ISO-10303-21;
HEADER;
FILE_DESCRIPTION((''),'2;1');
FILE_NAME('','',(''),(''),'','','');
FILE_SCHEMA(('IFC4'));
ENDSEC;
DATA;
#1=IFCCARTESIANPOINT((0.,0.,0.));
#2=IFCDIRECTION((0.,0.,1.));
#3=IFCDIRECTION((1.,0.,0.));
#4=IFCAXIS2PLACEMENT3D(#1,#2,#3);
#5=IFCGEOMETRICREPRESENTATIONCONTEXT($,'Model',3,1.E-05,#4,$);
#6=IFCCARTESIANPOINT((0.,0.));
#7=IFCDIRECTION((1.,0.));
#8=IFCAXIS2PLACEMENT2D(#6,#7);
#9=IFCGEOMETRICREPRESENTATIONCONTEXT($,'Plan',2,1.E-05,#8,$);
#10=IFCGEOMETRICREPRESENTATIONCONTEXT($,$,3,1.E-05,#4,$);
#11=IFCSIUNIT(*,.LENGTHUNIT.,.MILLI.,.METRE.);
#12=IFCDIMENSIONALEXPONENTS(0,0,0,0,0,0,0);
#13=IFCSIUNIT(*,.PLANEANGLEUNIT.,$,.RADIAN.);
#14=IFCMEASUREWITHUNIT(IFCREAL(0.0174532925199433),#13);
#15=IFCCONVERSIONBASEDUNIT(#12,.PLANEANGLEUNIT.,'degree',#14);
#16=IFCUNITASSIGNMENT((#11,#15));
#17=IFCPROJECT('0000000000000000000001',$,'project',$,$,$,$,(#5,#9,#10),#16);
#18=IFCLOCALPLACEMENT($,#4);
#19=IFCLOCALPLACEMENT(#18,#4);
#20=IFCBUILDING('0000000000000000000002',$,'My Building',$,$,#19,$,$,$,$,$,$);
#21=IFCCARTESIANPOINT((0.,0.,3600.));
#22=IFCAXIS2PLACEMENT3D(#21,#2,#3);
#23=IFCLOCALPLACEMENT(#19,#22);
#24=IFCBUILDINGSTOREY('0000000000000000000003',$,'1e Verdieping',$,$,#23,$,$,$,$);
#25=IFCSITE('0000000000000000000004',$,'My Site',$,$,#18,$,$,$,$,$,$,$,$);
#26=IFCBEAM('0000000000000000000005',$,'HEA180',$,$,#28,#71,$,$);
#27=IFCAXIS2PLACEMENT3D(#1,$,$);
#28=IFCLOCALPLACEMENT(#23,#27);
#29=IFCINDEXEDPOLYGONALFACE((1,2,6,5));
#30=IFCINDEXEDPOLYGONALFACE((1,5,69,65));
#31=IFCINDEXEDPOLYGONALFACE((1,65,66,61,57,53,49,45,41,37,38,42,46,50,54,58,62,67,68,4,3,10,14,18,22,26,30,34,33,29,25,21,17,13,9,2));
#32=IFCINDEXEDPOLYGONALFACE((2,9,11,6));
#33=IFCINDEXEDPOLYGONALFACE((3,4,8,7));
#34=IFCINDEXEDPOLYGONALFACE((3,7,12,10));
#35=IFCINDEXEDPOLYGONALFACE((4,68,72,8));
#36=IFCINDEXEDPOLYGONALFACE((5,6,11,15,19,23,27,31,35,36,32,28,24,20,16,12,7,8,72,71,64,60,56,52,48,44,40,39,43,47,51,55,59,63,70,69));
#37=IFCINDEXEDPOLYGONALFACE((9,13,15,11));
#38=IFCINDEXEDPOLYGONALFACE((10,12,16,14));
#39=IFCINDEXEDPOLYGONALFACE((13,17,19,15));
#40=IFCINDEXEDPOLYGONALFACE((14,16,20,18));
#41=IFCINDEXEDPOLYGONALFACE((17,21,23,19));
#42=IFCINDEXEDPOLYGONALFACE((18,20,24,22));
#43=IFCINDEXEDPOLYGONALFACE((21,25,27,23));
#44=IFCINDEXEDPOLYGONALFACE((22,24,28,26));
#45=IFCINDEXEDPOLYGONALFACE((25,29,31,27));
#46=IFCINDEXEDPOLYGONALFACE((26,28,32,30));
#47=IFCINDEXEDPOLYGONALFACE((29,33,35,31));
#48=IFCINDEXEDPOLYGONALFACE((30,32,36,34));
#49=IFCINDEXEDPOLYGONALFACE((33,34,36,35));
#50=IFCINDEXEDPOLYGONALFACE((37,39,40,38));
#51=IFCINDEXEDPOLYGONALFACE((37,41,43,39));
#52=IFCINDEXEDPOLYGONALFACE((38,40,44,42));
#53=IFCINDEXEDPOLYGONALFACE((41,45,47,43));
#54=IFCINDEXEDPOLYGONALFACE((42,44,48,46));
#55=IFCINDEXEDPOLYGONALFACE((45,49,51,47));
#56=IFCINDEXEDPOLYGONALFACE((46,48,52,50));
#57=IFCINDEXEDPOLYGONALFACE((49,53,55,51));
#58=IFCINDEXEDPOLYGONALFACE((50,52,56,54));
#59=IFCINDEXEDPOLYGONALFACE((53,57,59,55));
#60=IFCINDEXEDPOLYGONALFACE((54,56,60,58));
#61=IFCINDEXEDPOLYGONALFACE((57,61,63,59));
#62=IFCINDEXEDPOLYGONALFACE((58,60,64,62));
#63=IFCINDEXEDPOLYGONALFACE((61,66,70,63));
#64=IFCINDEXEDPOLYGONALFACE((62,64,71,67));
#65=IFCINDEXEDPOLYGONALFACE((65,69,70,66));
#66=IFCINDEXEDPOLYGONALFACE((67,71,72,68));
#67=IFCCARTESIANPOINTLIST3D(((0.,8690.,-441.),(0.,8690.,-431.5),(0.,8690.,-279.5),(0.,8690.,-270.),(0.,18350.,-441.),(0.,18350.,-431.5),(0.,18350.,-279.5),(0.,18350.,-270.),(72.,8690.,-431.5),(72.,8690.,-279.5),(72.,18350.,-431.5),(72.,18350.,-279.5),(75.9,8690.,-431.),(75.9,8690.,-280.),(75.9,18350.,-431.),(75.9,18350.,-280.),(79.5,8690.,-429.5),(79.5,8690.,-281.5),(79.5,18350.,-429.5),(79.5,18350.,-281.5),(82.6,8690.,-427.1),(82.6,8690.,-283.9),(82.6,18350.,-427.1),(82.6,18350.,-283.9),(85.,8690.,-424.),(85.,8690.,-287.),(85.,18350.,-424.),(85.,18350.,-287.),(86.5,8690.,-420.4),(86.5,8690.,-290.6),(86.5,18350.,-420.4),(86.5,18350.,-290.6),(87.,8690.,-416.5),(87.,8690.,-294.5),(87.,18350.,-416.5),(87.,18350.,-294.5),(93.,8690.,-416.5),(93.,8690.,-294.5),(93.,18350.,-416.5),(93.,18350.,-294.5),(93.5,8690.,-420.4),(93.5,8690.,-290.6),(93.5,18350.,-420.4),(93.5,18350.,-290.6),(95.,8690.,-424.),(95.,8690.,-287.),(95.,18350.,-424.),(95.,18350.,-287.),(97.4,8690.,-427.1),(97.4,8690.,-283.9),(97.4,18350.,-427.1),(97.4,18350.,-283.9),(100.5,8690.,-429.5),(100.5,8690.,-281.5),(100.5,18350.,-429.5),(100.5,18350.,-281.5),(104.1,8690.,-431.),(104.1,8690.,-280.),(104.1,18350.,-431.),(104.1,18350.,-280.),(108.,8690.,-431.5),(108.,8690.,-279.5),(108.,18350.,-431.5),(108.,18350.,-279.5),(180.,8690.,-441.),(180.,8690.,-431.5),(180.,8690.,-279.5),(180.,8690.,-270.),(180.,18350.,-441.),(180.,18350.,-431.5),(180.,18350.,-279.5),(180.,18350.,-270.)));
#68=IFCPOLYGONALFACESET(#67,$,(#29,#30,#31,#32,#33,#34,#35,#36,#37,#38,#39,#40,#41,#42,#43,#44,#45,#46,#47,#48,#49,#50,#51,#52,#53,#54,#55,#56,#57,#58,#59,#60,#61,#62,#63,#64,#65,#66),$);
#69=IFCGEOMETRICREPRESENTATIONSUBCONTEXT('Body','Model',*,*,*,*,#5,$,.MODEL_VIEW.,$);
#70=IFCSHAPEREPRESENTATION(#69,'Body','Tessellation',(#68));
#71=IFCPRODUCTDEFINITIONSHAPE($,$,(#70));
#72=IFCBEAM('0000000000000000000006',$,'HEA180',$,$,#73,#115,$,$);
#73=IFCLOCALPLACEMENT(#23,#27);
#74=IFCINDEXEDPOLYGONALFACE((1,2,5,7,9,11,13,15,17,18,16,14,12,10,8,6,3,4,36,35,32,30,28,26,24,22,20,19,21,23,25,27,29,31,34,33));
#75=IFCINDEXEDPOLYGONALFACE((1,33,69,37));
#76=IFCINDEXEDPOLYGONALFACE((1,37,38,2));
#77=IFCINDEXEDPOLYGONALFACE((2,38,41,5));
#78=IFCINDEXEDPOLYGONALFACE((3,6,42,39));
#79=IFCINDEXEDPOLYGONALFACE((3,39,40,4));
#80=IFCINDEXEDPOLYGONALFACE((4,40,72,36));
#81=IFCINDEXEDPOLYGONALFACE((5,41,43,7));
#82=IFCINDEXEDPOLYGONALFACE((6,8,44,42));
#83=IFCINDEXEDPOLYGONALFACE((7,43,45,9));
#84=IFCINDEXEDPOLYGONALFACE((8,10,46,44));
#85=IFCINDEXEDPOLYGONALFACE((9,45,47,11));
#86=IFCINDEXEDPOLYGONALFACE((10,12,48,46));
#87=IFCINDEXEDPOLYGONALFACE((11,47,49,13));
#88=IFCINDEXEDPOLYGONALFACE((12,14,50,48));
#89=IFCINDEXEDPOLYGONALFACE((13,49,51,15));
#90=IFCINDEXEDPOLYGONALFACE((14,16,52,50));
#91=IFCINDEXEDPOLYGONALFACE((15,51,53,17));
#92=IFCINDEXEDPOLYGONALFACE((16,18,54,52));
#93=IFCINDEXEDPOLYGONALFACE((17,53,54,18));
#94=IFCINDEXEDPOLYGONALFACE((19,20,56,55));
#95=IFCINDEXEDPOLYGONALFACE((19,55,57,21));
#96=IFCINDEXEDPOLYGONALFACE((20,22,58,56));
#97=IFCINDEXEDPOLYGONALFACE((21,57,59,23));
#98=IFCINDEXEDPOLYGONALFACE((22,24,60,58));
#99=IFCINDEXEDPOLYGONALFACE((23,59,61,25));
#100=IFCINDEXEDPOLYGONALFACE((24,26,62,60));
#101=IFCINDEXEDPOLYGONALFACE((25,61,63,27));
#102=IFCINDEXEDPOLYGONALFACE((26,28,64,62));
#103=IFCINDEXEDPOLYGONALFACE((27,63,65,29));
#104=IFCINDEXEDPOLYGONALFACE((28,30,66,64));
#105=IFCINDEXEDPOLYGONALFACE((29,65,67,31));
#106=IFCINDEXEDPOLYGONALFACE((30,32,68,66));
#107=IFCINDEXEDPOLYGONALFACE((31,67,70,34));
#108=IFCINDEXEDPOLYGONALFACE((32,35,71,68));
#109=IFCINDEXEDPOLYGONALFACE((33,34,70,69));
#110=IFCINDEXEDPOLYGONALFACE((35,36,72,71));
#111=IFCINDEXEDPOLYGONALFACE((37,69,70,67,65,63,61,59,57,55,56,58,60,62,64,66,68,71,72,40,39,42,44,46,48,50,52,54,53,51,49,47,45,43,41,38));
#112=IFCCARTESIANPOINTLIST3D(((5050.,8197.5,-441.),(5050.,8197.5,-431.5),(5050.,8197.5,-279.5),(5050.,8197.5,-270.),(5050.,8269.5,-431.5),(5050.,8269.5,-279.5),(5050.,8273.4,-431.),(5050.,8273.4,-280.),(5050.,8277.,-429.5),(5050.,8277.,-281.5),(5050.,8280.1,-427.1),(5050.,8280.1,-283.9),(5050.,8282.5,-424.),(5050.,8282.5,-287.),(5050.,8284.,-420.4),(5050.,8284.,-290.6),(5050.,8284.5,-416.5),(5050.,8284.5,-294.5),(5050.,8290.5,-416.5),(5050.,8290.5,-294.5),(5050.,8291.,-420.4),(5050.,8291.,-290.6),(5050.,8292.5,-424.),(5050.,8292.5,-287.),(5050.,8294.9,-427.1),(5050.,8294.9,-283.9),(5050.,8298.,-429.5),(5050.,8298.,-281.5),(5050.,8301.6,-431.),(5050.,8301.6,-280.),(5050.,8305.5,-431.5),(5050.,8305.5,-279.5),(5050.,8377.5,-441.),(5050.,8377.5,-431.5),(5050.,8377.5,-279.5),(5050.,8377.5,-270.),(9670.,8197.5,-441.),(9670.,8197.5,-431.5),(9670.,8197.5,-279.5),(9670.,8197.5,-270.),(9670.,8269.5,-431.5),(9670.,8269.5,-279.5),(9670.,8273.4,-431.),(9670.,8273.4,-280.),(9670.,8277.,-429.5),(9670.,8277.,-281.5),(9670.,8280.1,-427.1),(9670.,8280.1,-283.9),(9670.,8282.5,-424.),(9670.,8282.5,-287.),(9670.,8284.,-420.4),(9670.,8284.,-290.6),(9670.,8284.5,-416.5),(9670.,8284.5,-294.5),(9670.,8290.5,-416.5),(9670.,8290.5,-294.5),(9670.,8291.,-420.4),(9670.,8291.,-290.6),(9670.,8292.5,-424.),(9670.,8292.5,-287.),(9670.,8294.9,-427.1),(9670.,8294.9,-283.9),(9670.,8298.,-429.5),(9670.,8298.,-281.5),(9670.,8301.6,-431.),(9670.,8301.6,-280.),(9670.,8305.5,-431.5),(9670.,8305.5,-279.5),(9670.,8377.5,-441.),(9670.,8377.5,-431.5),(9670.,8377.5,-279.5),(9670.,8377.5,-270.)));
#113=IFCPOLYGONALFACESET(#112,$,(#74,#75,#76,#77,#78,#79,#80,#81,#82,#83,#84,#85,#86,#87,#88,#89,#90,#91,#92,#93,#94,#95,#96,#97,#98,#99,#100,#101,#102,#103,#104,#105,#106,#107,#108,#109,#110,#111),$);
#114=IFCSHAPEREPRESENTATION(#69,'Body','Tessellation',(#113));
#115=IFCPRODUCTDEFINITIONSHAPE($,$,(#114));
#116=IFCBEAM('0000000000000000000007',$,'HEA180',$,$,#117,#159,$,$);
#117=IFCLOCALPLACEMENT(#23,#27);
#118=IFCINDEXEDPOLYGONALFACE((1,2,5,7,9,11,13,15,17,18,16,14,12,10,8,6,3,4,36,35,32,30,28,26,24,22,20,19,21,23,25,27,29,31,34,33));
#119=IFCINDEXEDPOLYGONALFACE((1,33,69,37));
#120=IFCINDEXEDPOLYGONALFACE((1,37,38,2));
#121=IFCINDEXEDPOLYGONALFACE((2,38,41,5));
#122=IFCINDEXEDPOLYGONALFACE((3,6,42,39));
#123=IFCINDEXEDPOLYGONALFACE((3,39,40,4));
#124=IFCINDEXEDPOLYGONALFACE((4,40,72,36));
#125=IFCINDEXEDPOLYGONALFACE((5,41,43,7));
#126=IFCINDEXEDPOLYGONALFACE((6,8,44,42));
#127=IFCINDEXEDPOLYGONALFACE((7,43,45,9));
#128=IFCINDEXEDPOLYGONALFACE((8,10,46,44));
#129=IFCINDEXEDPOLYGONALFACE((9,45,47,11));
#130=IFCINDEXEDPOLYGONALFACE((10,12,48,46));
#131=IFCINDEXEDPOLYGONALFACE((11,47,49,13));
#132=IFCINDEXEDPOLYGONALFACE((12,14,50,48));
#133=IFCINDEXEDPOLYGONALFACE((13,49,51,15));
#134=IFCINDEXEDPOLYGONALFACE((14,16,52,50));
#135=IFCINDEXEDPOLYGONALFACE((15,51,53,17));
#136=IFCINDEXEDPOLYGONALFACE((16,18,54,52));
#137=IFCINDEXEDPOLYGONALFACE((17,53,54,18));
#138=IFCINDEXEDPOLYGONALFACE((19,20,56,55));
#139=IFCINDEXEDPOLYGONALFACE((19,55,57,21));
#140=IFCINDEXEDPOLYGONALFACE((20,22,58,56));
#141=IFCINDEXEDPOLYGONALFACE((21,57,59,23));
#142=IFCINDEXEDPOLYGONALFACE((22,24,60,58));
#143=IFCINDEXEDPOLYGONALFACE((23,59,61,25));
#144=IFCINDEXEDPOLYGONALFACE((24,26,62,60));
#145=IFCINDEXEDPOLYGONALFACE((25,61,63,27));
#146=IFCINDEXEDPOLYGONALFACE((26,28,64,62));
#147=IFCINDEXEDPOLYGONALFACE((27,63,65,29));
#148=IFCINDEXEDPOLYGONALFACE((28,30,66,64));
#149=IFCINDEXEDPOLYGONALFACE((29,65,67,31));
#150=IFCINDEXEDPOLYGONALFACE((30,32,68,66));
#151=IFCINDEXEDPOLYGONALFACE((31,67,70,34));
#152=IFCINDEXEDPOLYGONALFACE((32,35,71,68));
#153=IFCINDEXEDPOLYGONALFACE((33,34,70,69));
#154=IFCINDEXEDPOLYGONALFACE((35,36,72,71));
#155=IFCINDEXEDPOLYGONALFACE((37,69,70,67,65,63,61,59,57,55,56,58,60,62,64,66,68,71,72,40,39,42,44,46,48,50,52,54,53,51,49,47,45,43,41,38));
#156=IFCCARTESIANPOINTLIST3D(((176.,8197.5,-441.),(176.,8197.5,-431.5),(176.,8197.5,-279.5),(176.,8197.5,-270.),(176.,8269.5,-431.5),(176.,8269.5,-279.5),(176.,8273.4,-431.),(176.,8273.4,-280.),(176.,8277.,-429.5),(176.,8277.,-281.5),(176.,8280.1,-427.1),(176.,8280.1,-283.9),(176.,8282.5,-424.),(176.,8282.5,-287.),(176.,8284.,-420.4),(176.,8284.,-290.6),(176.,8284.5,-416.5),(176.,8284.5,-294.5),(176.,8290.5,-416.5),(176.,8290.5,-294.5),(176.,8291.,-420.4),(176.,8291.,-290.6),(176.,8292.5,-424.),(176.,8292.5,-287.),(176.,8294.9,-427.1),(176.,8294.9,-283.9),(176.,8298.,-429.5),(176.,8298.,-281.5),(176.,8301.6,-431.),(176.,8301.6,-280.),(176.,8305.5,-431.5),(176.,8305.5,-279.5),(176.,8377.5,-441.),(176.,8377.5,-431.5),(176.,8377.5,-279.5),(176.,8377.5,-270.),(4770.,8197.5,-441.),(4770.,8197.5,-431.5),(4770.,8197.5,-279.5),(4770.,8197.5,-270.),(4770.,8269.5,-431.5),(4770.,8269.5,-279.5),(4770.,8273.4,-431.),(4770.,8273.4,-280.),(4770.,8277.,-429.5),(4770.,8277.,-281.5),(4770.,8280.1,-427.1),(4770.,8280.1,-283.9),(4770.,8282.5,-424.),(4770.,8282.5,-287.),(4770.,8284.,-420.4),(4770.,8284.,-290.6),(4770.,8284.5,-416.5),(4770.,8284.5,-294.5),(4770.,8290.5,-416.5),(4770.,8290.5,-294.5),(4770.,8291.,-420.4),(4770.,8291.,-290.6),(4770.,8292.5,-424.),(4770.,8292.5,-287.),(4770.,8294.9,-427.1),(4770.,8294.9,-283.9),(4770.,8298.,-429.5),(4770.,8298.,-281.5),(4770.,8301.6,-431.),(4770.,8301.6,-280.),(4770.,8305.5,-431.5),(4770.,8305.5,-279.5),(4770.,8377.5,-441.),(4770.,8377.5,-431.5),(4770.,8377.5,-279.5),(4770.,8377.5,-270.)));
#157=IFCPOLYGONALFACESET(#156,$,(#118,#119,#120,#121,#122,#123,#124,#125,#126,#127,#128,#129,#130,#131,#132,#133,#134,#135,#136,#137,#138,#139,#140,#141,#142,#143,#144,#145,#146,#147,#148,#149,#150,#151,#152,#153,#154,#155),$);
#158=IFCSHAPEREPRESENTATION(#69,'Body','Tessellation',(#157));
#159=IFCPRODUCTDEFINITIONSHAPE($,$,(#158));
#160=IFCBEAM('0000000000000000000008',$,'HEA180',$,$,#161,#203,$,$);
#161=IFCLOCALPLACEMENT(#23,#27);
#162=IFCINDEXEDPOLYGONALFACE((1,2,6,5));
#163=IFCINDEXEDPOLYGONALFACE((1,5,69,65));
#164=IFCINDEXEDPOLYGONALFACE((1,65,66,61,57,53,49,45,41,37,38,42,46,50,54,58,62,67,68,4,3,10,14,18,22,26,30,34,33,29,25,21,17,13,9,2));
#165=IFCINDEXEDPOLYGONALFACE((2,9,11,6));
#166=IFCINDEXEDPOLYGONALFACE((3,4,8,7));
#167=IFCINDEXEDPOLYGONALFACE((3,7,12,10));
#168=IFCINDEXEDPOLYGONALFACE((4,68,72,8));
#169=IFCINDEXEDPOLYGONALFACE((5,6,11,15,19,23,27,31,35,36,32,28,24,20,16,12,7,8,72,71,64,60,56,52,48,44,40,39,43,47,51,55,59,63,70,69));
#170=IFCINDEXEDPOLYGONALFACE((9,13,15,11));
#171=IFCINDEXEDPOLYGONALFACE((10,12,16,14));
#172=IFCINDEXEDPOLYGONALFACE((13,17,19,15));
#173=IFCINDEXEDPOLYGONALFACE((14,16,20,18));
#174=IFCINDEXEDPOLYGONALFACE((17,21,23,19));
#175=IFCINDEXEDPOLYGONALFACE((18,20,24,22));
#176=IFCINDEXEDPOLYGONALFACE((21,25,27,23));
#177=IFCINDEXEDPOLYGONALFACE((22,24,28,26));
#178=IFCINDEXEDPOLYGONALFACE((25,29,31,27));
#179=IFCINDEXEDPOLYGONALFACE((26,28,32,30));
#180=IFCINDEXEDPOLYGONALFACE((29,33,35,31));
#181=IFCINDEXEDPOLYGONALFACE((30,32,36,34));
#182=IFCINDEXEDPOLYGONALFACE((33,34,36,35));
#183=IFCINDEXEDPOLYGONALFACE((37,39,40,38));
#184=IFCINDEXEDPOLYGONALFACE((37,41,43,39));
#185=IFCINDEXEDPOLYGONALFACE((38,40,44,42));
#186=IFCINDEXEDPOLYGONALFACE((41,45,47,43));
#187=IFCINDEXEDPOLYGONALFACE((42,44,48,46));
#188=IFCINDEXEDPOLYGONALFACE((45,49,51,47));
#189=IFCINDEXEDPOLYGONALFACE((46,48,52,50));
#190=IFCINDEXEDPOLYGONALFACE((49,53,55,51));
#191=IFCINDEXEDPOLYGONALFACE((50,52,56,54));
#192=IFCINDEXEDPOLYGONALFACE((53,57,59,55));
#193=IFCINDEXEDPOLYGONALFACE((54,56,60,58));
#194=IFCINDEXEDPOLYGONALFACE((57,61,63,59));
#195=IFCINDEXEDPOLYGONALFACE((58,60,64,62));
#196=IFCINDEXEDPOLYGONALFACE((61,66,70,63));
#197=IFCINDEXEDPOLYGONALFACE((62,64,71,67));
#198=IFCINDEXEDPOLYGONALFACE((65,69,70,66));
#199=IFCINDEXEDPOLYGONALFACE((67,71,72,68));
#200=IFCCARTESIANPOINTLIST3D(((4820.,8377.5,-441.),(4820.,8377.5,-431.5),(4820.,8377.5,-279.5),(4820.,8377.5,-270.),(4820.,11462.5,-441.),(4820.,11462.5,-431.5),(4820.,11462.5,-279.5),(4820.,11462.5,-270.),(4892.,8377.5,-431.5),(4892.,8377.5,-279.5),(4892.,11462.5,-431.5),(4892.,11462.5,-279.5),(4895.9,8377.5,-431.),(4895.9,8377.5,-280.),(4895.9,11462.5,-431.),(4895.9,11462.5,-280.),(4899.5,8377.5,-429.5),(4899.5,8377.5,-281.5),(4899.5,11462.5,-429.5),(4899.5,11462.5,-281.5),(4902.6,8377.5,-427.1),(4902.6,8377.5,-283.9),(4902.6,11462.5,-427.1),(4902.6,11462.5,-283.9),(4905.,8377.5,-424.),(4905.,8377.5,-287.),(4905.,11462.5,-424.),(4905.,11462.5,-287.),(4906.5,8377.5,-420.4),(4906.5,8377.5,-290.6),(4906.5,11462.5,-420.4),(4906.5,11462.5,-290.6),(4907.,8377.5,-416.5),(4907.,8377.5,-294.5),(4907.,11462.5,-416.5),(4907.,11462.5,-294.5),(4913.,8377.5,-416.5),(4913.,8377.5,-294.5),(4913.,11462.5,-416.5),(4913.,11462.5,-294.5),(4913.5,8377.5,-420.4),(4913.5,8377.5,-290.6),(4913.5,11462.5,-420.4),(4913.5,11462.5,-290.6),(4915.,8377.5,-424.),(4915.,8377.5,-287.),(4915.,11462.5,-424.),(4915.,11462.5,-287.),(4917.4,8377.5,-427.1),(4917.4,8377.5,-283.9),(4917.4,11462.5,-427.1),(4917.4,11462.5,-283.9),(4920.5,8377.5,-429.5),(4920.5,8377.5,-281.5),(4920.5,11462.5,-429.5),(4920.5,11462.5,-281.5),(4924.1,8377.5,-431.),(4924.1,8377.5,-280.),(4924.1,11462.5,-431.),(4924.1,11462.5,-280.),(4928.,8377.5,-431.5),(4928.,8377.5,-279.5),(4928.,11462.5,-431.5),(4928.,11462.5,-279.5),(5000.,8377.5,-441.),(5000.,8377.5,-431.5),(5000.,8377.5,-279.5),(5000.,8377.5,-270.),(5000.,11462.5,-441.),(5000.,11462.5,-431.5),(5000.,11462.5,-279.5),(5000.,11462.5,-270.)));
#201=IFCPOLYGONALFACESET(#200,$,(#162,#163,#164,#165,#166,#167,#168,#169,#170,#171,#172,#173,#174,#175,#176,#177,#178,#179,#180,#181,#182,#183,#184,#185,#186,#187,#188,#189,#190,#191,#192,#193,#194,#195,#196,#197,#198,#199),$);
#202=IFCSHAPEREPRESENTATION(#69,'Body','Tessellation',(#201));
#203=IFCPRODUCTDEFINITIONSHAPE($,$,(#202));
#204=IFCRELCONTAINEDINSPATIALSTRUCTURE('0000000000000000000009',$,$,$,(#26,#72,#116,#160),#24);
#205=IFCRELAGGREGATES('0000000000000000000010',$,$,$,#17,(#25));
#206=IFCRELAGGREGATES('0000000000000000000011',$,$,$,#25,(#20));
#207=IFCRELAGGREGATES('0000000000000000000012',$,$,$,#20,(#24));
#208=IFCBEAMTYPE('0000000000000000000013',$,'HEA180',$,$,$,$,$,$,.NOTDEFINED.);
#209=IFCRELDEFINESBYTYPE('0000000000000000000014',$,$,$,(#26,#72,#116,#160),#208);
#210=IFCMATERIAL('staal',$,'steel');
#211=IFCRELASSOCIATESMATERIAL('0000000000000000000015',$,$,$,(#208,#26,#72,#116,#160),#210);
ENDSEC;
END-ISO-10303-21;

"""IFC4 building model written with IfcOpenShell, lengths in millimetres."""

from ifc_helpers import new_model, entity, si_unit, converted_unit, frame, origin_with_axes, origin_2d_with_axis, place, context, subcontext, project, spatial, i_section, extrude, material, material_profile, profile_set, profile_usage, type_object, element, save


model = new_model("IFC4")

# Units and contexts
model_context = context("Model", 3, precision=1e-05, world=origin_with_axes())
plan_context = context("Plan", 2, precision=1e-05, world=origin_2d_with_axis())
context_of_model = context(None, 3, precision=1e-05, world=origin_with_axes())
body_context = subcontext(model_context, "Body", "Model", "MODEL_VIEW")
ifc_project = project(units=[si_unit("LENGTHUNIT", "METRE", prefix="MILLI"), converted_unit("PLANEANGLEUNIT", "degree", entity("IfcReal", 0.0174532925199433), si_unit("PLANEANGLEUNIT", "RADIAN"), dimensions=[0, 0, 0, 0, 0, 0, 0])], contexts=[model_context, plan_context, context_of_model])

# Site, building, storey
site_placement = place(None, origin_with_axes())
site = spatial("IfcSite", under=ifc_project, at=site_placement, Name="My Site")
building_placement = place(site_placement, origin_with_axes())
building = spatial("IfcBuilding", under=site, at=building_placement, Name="My Building")
storey_placement = place(building_placement, frame((0.0, 0.0, 3600.0), z_axis=(0.0, 0.0, 1.0), x_axis=(1.0, 0.0, 0.0)))
storey = spatial("IfcBuildingStorey", under=building, at=storey_placement, Name="1e Verdieping")

# Shared definitions
ifc_material = material(Name="staal", Category="steel")

# Beams
ifc_material_profile_1 = material_profile(ifc_material, i_section(OverallWidth=180.0, OverallDepth=171.0, WebThickness=6.0, FlangeThickness=9.5, FilletRadius=15.0))
ifc_profile_set_1 = profile_set([ifc_material_profile_1], Name="HEA180")
beam_type_1 = type_object("IfcBeamType", Name="HEA180", PredefinedType="NOTDEFINED", material=ifc_profile_set_1)
ifc_profile_usage_1 = profile_usage(ifc_profile_set_1, cardinal=5)
beam_1_placement = place(storey_placement, frame((90.0, 8690.0, -355.5), z_axis=(0.0, 1.0, 0.0), x_axis=(-1.0, 0.0, 0.0)))
element("IfcBeam", 1, at=beam_1_placement, inside=storey, type_object=beam_type_1, material=ifc_profile_usage_1, Name="HEA180", context=body_context, shape_type="SweptSolid", body=[
    extrude(i_section(OverallWidth=180.0, OverallDepth=171.0, WebThickness=6.0, FlangeThickness=9.5, FilletRadius=15.0), origin_with_axes(), (0.0, 0.0, 1.0), 9660.0),
])
ifc_profile_usage_2 = profile_usage(ifc_profile_set_1)
beam_2_placement = place(storey_placement, frame((5050.0, 8287.5, -355.5), z_axis=(1.0, 0.0, 0.0), x_axis=(0.0, 1.0, 0.0)))
element("IfcBeam", 2, at=beam_2_placement, inside=storey, type_object=beam_type_1, material=ifc_profile_usage_2, Name="HEA180", context=body_context, shape_type="SweptSolid", body=[
    extrude(i_section(OverallWidth=180.0, OverallDepth=171.0, WebThickness=6.0, FlangeThickness=9.5, FilletRadius=15.0), origin_with_axes(), (0.0, 0.0, 1.0), 4620.0),
])
ifc_profile_usage_3 = profile_usage(ifc_profile_set_1)
beam_3_placement = place(storey_placement, frame((176.0, 8287.5, -355.5), z_axis=(1.0, 0.0, 0.0), x_axis=(0.0, 1.0, 0.0)))
element("IfcBeam", 3, at=beam_3_placement, inside=storey, type_object=beam_type_1, material=ifc_profile_usage_3, Name="HEA180", context=body_context, shape_type="SweptSolid", body=[
    extrude(i_section(OverallWidth=180.0, OverallDepth=171.0, WebThickness=6.0, FlangeThickness=9.5, FilletRadius=15.0), origin_with_axes(), (0.0, 0.0, 1.0), 4594.0),
])
ifc_profile_usage_4 = profile_usage(ifc_profile_set_1)
beam_4_placement = place(storey_placement, frame((4910.0, 8377.5, -355.5), z_axis=(0.0, 1.0, 0.0), x_axis=(-1.0, 0.0, 0.0)))
element("IfcBeam", 4, at=beam_4_placement, inside=storey, type_object=beam_type_1, material=ifc_profile_usage_4, Name="HEA180", context=body_context, shape_type="SweptSolid", body=[
    extrude(i_section(OverallWidth=180.0, OverallDepth=171.0, WebThickness=6.0, FlangeThickness=9.5, FilletRadius=15.0), origin_with_axes(), (0.0, 0.0, 1.0), 3085.0),
])

save(model, "model.ifc")
